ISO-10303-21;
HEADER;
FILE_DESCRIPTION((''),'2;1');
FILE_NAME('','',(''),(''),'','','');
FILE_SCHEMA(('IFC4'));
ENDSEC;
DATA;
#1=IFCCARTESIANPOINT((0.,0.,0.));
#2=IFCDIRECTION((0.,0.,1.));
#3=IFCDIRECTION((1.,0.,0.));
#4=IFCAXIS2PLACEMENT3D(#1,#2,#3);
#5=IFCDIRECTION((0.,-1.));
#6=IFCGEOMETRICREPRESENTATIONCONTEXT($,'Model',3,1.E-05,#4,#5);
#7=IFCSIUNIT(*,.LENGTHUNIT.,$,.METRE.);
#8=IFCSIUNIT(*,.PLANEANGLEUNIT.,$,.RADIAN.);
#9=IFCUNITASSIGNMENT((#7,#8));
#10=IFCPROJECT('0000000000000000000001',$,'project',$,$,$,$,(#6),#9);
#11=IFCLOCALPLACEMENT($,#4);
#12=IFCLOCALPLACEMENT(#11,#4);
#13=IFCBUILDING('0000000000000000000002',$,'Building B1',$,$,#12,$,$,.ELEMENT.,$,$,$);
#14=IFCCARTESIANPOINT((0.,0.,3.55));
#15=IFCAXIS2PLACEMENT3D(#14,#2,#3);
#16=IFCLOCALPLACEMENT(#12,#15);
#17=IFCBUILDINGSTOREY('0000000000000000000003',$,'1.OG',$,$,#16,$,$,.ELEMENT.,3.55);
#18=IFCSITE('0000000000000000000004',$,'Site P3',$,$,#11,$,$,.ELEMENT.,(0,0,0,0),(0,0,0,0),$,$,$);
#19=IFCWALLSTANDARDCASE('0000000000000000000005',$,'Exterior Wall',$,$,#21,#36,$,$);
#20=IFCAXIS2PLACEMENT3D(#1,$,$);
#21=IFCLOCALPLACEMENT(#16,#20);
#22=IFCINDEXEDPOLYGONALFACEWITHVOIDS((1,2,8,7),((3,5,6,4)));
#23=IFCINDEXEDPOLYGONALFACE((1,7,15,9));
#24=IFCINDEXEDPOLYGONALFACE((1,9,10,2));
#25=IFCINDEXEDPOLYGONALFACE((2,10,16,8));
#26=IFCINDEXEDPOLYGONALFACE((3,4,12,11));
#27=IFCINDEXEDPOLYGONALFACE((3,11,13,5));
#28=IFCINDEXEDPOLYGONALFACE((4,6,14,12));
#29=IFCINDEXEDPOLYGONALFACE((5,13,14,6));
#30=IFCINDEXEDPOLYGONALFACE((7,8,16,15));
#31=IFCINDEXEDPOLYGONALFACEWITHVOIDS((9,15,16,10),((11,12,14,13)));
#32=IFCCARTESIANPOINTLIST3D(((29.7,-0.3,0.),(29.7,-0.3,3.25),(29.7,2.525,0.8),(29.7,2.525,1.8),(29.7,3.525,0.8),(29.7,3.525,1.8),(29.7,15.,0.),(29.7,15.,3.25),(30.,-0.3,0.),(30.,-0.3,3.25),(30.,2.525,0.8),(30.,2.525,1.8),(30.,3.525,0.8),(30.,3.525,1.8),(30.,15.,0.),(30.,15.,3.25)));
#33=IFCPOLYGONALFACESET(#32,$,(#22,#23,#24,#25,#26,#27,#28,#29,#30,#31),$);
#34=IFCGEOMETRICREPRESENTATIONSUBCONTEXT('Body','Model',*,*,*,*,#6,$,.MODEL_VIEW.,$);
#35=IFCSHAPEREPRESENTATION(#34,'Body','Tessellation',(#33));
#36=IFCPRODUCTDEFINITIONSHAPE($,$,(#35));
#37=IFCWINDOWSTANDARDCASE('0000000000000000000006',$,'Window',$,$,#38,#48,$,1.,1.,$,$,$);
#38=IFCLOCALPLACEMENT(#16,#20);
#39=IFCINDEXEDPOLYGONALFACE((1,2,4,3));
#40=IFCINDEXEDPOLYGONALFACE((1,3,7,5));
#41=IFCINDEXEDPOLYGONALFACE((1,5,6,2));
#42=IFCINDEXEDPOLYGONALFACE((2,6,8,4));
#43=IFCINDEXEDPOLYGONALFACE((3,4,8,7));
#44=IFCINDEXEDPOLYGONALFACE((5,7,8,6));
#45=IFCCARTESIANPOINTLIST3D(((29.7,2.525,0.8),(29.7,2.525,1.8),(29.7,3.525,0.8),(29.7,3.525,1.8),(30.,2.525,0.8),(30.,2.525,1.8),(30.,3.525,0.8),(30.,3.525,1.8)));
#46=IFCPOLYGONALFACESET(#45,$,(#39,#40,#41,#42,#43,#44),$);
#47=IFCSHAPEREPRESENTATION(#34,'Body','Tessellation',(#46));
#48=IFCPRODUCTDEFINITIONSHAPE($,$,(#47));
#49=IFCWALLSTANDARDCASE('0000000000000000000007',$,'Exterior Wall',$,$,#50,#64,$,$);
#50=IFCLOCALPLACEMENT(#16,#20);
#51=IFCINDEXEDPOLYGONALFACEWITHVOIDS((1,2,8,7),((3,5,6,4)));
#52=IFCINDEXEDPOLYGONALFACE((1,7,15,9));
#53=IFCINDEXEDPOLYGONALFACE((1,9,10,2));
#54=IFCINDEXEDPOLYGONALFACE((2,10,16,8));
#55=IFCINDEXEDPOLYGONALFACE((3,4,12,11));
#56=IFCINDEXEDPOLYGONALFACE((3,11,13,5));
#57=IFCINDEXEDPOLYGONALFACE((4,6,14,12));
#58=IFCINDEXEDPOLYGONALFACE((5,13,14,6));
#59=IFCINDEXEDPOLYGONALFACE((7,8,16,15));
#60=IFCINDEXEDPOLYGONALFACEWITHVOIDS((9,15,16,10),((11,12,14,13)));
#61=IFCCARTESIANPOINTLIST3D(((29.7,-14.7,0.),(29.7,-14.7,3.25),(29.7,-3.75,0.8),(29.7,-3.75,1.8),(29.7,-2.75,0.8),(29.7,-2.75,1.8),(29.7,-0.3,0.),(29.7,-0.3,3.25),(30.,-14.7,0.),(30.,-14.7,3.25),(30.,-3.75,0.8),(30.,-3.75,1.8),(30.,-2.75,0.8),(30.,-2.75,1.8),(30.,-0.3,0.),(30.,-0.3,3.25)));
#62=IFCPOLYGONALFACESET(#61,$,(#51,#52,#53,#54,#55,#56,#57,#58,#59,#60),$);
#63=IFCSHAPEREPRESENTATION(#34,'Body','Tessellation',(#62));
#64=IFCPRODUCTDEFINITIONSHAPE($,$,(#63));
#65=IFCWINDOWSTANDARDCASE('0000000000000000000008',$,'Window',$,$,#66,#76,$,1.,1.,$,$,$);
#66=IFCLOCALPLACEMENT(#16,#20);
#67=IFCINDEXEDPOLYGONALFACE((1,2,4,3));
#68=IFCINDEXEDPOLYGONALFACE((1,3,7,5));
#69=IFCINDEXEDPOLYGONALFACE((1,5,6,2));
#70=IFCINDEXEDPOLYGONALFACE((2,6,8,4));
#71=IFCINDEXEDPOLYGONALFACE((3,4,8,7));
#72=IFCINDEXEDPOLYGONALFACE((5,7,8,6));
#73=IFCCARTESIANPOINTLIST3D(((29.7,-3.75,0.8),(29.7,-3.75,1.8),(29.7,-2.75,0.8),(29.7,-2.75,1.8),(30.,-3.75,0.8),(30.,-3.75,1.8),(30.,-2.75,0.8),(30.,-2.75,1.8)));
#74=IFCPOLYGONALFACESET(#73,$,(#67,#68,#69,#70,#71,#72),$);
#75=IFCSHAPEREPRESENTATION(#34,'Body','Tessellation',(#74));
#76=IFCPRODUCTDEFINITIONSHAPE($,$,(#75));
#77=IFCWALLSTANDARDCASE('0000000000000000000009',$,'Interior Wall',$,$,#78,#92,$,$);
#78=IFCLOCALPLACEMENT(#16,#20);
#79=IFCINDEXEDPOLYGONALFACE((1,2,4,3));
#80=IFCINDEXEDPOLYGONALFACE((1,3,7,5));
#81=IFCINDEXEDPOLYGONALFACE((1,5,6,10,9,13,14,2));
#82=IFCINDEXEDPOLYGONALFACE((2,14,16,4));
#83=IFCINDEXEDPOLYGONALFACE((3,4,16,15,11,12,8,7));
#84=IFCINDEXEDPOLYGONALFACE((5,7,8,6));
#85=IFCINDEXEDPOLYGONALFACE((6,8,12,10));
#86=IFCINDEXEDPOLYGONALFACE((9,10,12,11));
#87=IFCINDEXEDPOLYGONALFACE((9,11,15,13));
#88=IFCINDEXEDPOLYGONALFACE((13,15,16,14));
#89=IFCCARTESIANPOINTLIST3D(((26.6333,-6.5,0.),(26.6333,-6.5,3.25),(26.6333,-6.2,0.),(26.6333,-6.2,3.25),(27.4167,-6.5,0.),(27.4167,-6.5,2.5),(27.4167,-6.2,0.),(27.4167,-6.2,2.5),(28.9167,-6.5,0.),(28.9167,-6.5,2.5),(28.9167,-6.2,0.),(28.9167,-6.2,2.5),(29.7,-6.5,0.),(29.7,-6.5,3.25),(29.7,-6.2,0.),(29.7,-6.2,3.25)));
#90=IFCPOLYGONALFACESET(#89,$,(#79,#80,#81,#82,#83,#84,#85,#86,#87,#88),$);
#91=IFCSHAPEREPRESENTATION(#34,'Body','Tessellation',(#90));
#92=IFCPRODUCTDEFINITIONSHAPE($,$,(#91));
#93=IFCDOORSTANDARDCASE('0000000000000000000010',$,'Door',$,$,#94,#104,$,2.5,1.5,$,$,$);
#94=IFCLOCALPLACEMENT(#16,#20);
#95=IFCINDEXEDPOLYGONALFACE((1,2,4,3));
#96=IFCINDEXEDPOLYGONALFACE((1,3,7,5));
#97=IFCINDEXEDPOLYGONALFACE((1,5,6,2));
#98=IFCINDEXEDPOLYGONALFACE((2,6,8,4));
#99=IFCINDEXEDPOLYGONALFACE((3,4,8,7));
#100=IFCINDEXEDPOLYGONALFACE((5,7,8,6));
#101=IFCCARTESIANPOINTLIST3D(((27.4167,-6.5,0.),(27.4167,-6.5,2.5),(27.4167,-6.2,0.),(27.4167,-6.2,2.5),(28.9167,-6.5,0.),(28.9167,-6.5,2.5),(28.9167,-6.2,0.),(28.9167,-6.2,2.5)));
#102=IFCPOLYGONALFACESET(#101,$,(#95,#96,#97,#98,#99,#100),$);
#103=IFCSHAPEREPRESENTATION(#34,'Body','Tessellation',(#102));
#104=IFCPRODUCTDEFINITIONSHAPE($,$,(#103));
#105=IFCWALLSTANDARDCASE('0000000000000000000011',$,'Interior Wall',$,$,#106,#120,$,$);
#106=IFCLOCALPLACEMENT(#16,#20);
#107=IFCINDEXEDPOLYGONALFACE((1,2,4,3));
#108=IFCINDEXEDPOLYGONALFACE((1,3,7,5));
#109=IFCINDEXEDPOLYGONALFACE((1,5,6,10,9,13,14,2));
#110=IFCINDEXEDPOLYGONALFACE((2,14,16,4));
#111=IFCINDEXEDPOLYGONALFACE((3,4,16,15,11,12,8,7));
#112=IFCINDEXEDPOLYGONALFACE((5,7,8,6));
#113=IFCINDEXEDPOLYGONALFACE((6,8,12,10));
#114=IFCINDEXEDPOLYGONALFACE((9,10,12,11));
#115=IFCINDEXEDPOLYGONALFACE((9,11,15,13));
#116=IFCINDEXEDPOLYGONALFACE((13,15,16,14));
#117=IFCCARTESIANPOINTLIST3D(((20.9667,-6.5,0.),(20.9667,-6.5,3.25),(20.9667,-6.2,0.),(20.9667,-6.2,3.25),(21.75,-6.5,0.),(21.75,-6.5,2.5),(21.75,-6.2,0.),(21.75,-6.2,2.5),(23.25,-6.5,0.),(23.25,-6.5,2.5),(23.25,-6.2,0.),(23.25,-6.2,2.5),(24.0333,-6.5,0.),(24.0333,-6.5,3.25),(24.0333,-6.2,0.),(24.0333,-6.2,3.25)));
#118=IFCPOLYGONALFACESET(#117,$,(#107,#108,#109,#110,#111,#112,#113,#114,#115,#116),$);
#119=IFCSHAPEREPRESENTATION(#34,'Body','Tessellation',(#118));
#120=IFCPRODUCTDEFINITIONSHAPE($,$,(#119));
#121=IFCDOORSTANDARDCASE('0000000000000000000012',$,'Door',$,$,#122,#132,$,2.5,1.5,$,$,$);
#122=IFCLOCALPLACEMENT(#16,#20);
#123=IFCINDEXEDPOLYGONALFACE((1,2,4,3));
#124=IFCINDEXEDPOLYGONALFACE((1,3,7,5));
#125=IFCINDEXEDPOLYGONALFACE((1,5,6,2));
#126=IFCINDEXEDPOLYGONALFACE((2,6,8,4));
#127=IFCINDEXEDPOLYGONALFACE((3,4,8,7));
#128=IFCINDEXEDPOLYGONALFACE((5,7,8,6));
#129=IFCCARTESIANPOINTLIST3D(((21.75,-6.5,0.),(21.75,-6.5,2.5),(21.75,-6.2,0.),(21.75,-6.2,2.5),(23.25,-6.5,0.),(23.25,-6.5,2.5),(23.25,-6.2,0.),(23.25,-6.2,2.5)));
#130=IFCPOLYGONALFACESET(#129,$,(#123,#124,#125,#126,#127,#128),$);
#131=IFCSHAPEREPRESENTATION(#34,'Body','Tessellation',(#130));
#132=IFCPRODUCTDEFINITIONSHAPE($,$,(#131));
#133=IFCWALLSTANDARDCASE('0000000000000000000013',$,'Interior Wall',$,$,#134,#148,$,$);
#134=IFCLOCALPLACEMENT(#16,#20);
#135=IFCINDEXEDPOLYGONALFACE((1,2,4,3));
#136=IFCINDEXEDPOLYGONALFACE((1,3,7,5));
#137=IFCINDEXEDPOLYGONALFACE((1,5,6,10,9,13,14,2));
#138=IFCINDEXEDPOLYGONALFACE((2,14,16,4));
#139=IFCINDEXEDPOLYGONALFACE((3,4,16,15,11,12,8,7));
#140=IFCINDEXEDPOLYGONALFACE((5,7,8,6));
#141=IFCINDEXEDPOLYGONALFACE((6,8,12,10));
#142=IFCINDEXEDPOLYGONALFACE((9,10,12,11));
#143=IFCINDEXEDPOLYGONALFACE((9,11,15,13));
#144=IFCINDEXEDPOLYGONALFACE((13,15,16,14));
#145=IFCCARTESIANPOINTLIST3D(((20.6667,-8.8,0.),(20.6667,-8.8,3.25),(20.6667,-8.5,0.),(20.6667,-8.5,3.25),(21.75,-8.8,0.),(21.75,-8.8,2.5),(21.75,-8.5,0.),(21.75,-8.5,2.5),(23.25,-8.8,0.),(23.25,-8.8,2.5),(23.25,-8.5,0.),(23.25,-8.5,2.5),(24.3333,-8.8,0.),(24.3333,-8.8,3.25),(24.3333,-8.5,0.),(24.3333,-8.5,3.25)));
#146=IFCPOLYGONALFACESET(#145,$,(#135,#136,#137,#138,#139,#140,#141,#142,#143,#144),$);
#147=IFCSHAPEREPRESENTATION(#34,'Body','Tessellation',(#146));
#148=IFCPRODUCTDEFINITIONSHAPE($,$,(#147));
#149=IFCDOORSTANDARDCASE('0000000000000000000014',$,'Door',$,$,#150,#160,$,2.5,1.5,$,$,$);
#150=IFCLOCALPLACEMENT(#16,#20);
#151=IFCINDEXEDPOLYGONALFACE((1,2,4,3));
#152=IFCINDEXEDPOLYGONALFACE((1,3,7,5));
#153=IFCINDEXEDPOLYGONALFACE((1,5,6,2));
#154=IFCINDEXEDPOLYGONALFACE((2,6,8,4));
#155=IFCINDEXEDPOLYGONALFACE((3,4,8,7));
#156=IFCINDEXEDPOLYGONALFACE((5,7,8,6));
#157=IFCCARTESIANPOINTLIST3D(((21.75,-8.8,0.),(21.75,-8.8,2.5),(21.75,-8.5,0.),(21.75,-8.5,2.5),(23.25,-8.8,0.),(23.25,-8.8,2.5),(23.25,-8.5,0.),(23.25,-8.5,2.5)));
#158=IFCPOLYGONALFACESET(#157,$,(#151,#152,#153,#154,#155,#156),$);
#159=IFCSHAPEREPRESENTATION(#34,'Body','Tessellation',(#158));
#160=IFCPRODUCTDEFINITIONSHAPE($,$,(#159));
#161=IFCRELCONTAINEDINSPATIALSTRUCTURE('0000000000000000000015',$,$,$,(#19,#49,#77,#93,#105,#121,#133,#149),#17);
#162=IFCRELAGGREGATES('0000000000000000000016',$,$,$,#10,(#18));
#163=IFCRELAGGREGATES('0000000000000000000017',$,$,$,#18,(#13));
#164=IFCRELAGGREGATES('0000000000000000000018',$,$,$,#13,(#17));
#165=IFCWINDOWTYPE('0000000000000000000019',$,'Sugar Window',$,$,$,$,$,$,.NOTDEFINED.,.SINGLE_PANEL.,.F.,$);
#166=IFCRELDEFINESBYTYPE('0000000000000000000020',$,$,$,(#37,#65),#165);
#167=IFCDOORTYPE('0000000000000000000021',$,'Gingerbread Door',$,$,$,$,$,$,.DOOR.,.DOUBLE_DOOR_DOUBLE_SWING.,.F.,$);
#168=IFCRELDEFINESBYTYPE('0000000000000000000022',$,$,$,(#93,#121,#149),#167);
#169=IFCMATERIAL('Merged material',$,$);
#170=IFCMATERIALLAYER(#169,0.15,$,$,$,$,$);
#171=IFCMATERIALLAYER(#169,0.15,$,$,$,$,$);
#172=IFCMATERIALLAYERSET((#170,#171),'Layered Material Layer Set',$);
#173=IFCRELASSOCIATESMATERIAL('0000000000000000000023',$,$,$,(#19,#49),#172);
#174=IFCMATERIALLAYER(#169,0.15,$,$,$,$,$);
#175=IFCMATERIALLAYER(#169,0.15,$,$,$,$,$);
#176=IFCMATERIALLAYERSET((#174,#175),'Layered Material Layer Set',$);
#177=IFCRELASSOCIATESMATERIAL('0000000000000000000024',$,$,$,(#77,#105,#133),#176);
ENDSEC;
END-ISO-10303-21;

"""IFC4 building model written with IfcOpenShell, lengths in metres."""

from ifc_helpers import new_model, si_unit, direction, frame, origin_with_axes, place, context, subcontext, project, spatial, polyline, outline, extrude, source, transform, mapped, material, layer, layer_set, layer_usage, type_object, element, fill, save


model = new_model("IFC4")

# Units and contexts
model_context = context("Model", 3, precision=1e-05, world=origin_with_axes(), true_north=direction((0.0, -1.0)))
body_context = subcontext(model_context, "Body", "Model", "MODEL_VIEW")
ifc_project = project(units=[si_unit("LENGTHUNIT", "METRE"), si_unit("PLANEANGLEUNIT", "RADIAN")], contexts=[model_context])

# Site, building, storey
site_placement = place(None, origin_with_axes())
site = spatial("IfcSite", under=ifc_project, at=site_placement, Name="Site P3", CompositionType="ELEMENT", RefLatitude=(0, 0, 0, 0), RefLongitude=(0, 0, 0, 0))
building_placement = place(site_placement, origin_with_axes())
building = spatial("IfcBuilding", under=site, at=building_placement, Name="Building B1", CompositionType="ELEMENT")
storey_placement = place(building_placement, frame((0.0, 0.0, 3.55), z_axis=(0.0, 0.0, 1.0), x_axis=(1.0, 0.0, 0.0)))
storey = spatial("IfcBuildingStorey", under=building, at=storey_placement, Name="1.OG", CompositionType="ELEMENT", Elevation=3.55)

# Walls, openings, windows
ifc_material = material(Name="Merged material")
ifc_layer_1 = layer(ifc_material, 0.15)
ifc_layer_2 = layer(ifc_material, 0.15)
ifc_layer_set_1 = layer_set([ifc_layer_1, ifc_layer_2], Name="Layered Material Layer Set")
ifc_layer_usage_1 = layer_usage(ifc_layer_set_1, "AXIS2", "POSITIVE", -0.15)
wall_1_placement = place(storey_placement, frame((29.85, -0.3, 0.0), z_axis=(0.0, 0.0, 1.0), x_axis=(0.0, 1.0, 0.0)))
wall_1 = element("IfcWallStandardCase", 1, at=wall_1_placement, inside=storey, material=ifc_layer_usage_1, Name="Exterior Wall", context=body_context, shape_type="SweptSolid", body=[
    extrude(outline(polyline([(0.0, 0.15), (15.3, 0.15), (15.3, -0.15), (0.0, -0.15), (0.0, 0.15)])), origin_with_axes(), (0.0, 0.0, 1.0), 3.25),
])
opening_1_placement = place(wall_1_placement, frame((2.825, 0.0, 0.8), z_axis=(0.0, 0.0, 1.0), x_axis=(1.0, 0.0, 0.0)))
opening_1 = element("IfcOpeningStandardCase", 2, at=opening_1_placement, cuts=wall_1, context=body_context, shape_type="SweptSolid", body=[
    extrude(outline(polyline([(0.0, 0.0), (0.0, 1.0), (1.0, 1.0), (1.0, 0.0), (0.0, 0.0)])), frame((0.0, -0.15, 0.0), z_axis=(0.0, 1.0, 0.0), x_axis=(0.0, 0.0, 1.0)), (0.0, 0.0, 1.0), 0.3),
])
window_type = type_object("IfcWindowType", Name="Sugar Window", ParameterTakesPrecedence=False, PartitioningType="SINGLE_PANEL", PredefinedType="NOTDEFINED")
shared_shape_1 = source(origin_with_axes(), body_context, "Body", "SweptSolid", [
    extrude(outline(polyline([(0.0, 0.0), (0.0, 1.0), (1.0, 1.0), (1.0, 0.0), (0.0, 0.0)])), frame((0.0, -0.15, 0.0), z_axis=(0.0, 1.0, 0.0), x_axis=(0.0, 0.0, 1.0)), (0.0, 0.0, 1.0), 0.3),
])
window_1_placement = place(opening_1_placement, origin_with_axes())
window_1 = element("IfcWindowStandardCase", 3, at=window_1_placement, type_object=window_type, Name="Window", OverallHeight=1.0, OverallWidth=1.0, context=body_context, shape_type="MappedRepresentation", body=[
    mapped(shared_shape_1, transform((0.0, 0.0, 0.0))),
])
fill(opening_1, window_1)
wall_2_placement = place(storey_placement, frame((29.85, -14.7, 0.0), z_axis=(0.0, 0.0, 1.0), x_axis=(0.0, 1.0, 0.0)))
wall_2 = element("IfcWallStandardCase", 4, at=wall_2_placement, inside=storey, material=ifc_layer_usage_1, Name="Exterior Wall", context=body_context, shape_type="SweptSolid", body=[
    extrude(outline(polyline([(0.0, 0.15), (14.4, 0.15), (14.4, -0.15), (0.0, -0.15), (0.0, 0.15)])), origin_with_axes(), (0.0, 0.0, 1.0), 3.25),
])
opening_2_placement = place(wall_2_placement, frame((10.95, 0.0, 0.8), z_axis=(0.0, 0.0, 1.0), x_axis=(1.0, 0.0, 0.0)))
opening_2 = element("IfcOpeningStandardCase", 5, at=opening_2_placement, cuts=wall_2, context=body_context, shape_type="SweptSolid", body=[
    extrude(outline(polyline([(0.0, 0.0), (0.0, 1.0), (1.0, 1.0), (1.0, 0.0), (0.0, 0.0)])), frame((0.0, -0.15, 0.0), z_axis=(0.0, 1.0, 0.0), x_axis=(0.0, 0.0, 1.0)), (0.0, 0.0, 1.0), 0.3),
])
window_2_placement = place(opening_2_placement, origin_with_axes())
window_2 = element("IfcWindowStandardCase", 6, at=window_2_placement, type_object=window_type, Name="Window", OverallHeight=1.0, OverallWidth=1.0, context=body_context, shape_type="MappedRepresentation", body=[
    mapped(shared_shape_1, transform((0.0, 0.0, 0.0))),
])
fill(opening_2, window_2)

# Walls, openings, doors
ifc_layer_3 = layer(ifc_material, 0.15)
ifc_layer_4 = layer(ifc_material, 0.15)
ifc_layer_set_2 = layer_set([ifc_layer_3, ifc_layer_4], Name="Layered Material Layer Set")
ifc_layer_usage_2 = layer_usage(ifc_layer_set_2, "AXIS2", "POSITIVE", -0.15)
wall_3_placement = place(storey_placement, frame((26.6333, -6.35, 0.0), z_axis=(0.0, 0.0, 1.0), x_axis=(1.0, 0.0, 0.0)))
wall_3 = element("IfcWallStandardCase", 7, at=wall_3_placement, inside=storey, material=ifc_layer_usage_2, Name="Interior Wall", context=body_context, shape_type="SweptSolid", body=[
    extrude(outline(polyline([(0.0, 0.15), (3.0667, 0.15), (3.0667, -0.15), (0.0, -0.15), (0.0, 0.15)])), origin_with_axes(), (0.0, 0.0, 1.0), 3.25),
])
opening_3_placement = place(wall_3_placement, frame((0.7833, 0.0, 0.0), z_axis=(0.0, 0.0, 1.0), x_axis=(1.0, 0.0, 0.0)))
opening_3 = element("IfcOpeningStandardCase", 8, at=opening_3_placement, cuts=wall_3, context=body_context, shape_type="SweptSolid", body=[
    extrude(outline(polyline([(0.0, 0.0), (0.0, 1.5), (2.5, 1.5), (2.5, 0.0), (0.0, 0.0)])), frame((0.0, -0.15, 0.0), z_axis=(0.0, 1.0, 0.0), x_axis=(0.0, 0.0, 1.0)), (0.0, 0.0, 1.0), 0.3),
])
door_type = type_object("IfcDoorType", Name="Gingerbread Door", OperationType="DOUBLE_DOOR_DOUBLE_SWING", ParameterTakesPrecedence=False, PredefinedType="DOOR")
shared_shape_2 = source(origin_with_axes(), body_context, "Body", "SweptSolid", [
    extrude(outline(polyline([(0.0, 0.0), (0.0, 1.5), (2.5, 1.5), (2.5, 0.0), (0.0, 0.0)])), frame((0.0, -0.15, 0.0), z_axis=(0.0, 1.0, 0.0), x_axis=(0.0, 0.0, 1.0)), (0.0, 0.0, 1.0), 0.3),
])
door_1_placement = place(opening_3_placement, origin_with_axes())
door_1 = element("IfcDoorStandardCase", 9, at=door_1_placement, inside=storey, type_object=door_type, Name="Door", OverallHeight=2.5, OverallWidth=1.5, context=body_context, shape_type="MappedRepresentation", body=[
    mapped(shared_shape_2, transform((0.0, 0.0, 0.0))),
])
fill(opening_3, door_1)
wall_4_placement = place(storey_placement, frame((20.9667, -6.35, 0.0), z_axis=(0.0, 0.0, 1.0), x_axis=(1.0, 0.0, 0.0)))
wall_4 = element("IfcWallStandardCase", 10, at=wall_4_placement, inside=storey, material=ifc_layer_usage_2, Name="Interior Wall", context=body_context, shape_type="SweptSolid", body=[
    extrude(outline(polyline([(0.0, 0.15), (3.0667, 0.15), (3.0667, -0.15), (0.0, -0.15), (0.0, 0.15)])), origin_with_axes(), (0.0, 0.0, 1.0), 3.25),
])
opening_4_placement = place(wall_4_placement, frame((0.7833, 0.0, 0.0), z_axis=(0.0, 0.0, 1.0), x_axis=(1.0, 0.0, 0.0)))
opening_4 = element("IfcOpeningStandardCase", 11, at=opening_4_placement, cuts=wall_4, context=body_context, shape_type="SweptSolid", body=[
    extrude(outline(polyline([(0.0, 0.0), (0.0, 1.5), (2.5, 1.5), (2.5, 0.0), (0.0, 0.0)])), frame((0.0, -0.15, 0.0), z_axis=(0.0, 1.0, 0.0), x_axis=(0.0, 0.0, 1.0)), (0.0, 0.0, 1.0), 0.3),
])
door_2_placement = place(opening_4_placement, origin_with_axes())
door_2 = element("IfcDoorStandardCase", 12, at=door_2_placement, inside=storey, type_object=door_type, Name="Door", OverallHeight=2.5, OverallWidth=1.5, context=body_context, shape_type="MappedRepresentation", body=[
    mapped(shared_shape_2, transform((0.0, 0.0, 0.0))),
])
fill(opening_4, door_2)
wall_5_placement = place(storey_placement, frame((20.6667, -8.65, 0.0), z_axis=(0.0, 0.0, 1.0), x_axis=(1.0, 0.0, 0.0)))
wall_5 = element("IfcWallStandardCase", 13, at=wall_5_placement, inside=storey, material=ifc_layer_usage_2, Name="Interior Wall", context=body_context, shape_type="SweptSolid", body=[
    extrude(outline(polyline([(0.0, 0.15), (3.6667, 0.15), (3.6667, -0.15), (0.0, -0.15), (0.0, 0.15)])), origin_with_axes(), (0.0, 0.0, 1.0), 3.25),
])
opening_5_placement = place(wall_5_placement, frame((1.0833, 0.0, 0.0), z_axis=(0.0, 0.0, 1.0), x_axis=(1.0, 0.0, 0.0)))
opening_5 = element("IfcOpeningStandardCase", 14, at=opening_5_placement, cuts=wall_5, context=body_context, shape_type="SweptSolid", body=[
    extrude(outline(polyline([(0.0, 0.0), (0.0, 1.5), (2.5, 1.5), (2.5, 0.0), (0.0, 0.0)])), frame((0.0, -0.15, 0.0), z_axis=(0.0, 1.0, 0.0), x_axis=(0.0, 0.0, 1.0)), (0.0, 0.0, 1.0), 0.3),
])
door_3_placement = place(opening_5_placement, origin_with_axes())
door_3 = element("IfcDoorStandardCase", 15, at=door_3_placement, inside=storey, type_object=door_type, Name="Door", OverallHeight=2.5, OverallWidth=1.5, context=body_context, shape_type="MappedRepresentation", body=[
    mapped(shared_shape_2, transform((0.0, 0.0, 0.0))),
])
fill(opening_5, door_3)

save(model, "model.ifc")
